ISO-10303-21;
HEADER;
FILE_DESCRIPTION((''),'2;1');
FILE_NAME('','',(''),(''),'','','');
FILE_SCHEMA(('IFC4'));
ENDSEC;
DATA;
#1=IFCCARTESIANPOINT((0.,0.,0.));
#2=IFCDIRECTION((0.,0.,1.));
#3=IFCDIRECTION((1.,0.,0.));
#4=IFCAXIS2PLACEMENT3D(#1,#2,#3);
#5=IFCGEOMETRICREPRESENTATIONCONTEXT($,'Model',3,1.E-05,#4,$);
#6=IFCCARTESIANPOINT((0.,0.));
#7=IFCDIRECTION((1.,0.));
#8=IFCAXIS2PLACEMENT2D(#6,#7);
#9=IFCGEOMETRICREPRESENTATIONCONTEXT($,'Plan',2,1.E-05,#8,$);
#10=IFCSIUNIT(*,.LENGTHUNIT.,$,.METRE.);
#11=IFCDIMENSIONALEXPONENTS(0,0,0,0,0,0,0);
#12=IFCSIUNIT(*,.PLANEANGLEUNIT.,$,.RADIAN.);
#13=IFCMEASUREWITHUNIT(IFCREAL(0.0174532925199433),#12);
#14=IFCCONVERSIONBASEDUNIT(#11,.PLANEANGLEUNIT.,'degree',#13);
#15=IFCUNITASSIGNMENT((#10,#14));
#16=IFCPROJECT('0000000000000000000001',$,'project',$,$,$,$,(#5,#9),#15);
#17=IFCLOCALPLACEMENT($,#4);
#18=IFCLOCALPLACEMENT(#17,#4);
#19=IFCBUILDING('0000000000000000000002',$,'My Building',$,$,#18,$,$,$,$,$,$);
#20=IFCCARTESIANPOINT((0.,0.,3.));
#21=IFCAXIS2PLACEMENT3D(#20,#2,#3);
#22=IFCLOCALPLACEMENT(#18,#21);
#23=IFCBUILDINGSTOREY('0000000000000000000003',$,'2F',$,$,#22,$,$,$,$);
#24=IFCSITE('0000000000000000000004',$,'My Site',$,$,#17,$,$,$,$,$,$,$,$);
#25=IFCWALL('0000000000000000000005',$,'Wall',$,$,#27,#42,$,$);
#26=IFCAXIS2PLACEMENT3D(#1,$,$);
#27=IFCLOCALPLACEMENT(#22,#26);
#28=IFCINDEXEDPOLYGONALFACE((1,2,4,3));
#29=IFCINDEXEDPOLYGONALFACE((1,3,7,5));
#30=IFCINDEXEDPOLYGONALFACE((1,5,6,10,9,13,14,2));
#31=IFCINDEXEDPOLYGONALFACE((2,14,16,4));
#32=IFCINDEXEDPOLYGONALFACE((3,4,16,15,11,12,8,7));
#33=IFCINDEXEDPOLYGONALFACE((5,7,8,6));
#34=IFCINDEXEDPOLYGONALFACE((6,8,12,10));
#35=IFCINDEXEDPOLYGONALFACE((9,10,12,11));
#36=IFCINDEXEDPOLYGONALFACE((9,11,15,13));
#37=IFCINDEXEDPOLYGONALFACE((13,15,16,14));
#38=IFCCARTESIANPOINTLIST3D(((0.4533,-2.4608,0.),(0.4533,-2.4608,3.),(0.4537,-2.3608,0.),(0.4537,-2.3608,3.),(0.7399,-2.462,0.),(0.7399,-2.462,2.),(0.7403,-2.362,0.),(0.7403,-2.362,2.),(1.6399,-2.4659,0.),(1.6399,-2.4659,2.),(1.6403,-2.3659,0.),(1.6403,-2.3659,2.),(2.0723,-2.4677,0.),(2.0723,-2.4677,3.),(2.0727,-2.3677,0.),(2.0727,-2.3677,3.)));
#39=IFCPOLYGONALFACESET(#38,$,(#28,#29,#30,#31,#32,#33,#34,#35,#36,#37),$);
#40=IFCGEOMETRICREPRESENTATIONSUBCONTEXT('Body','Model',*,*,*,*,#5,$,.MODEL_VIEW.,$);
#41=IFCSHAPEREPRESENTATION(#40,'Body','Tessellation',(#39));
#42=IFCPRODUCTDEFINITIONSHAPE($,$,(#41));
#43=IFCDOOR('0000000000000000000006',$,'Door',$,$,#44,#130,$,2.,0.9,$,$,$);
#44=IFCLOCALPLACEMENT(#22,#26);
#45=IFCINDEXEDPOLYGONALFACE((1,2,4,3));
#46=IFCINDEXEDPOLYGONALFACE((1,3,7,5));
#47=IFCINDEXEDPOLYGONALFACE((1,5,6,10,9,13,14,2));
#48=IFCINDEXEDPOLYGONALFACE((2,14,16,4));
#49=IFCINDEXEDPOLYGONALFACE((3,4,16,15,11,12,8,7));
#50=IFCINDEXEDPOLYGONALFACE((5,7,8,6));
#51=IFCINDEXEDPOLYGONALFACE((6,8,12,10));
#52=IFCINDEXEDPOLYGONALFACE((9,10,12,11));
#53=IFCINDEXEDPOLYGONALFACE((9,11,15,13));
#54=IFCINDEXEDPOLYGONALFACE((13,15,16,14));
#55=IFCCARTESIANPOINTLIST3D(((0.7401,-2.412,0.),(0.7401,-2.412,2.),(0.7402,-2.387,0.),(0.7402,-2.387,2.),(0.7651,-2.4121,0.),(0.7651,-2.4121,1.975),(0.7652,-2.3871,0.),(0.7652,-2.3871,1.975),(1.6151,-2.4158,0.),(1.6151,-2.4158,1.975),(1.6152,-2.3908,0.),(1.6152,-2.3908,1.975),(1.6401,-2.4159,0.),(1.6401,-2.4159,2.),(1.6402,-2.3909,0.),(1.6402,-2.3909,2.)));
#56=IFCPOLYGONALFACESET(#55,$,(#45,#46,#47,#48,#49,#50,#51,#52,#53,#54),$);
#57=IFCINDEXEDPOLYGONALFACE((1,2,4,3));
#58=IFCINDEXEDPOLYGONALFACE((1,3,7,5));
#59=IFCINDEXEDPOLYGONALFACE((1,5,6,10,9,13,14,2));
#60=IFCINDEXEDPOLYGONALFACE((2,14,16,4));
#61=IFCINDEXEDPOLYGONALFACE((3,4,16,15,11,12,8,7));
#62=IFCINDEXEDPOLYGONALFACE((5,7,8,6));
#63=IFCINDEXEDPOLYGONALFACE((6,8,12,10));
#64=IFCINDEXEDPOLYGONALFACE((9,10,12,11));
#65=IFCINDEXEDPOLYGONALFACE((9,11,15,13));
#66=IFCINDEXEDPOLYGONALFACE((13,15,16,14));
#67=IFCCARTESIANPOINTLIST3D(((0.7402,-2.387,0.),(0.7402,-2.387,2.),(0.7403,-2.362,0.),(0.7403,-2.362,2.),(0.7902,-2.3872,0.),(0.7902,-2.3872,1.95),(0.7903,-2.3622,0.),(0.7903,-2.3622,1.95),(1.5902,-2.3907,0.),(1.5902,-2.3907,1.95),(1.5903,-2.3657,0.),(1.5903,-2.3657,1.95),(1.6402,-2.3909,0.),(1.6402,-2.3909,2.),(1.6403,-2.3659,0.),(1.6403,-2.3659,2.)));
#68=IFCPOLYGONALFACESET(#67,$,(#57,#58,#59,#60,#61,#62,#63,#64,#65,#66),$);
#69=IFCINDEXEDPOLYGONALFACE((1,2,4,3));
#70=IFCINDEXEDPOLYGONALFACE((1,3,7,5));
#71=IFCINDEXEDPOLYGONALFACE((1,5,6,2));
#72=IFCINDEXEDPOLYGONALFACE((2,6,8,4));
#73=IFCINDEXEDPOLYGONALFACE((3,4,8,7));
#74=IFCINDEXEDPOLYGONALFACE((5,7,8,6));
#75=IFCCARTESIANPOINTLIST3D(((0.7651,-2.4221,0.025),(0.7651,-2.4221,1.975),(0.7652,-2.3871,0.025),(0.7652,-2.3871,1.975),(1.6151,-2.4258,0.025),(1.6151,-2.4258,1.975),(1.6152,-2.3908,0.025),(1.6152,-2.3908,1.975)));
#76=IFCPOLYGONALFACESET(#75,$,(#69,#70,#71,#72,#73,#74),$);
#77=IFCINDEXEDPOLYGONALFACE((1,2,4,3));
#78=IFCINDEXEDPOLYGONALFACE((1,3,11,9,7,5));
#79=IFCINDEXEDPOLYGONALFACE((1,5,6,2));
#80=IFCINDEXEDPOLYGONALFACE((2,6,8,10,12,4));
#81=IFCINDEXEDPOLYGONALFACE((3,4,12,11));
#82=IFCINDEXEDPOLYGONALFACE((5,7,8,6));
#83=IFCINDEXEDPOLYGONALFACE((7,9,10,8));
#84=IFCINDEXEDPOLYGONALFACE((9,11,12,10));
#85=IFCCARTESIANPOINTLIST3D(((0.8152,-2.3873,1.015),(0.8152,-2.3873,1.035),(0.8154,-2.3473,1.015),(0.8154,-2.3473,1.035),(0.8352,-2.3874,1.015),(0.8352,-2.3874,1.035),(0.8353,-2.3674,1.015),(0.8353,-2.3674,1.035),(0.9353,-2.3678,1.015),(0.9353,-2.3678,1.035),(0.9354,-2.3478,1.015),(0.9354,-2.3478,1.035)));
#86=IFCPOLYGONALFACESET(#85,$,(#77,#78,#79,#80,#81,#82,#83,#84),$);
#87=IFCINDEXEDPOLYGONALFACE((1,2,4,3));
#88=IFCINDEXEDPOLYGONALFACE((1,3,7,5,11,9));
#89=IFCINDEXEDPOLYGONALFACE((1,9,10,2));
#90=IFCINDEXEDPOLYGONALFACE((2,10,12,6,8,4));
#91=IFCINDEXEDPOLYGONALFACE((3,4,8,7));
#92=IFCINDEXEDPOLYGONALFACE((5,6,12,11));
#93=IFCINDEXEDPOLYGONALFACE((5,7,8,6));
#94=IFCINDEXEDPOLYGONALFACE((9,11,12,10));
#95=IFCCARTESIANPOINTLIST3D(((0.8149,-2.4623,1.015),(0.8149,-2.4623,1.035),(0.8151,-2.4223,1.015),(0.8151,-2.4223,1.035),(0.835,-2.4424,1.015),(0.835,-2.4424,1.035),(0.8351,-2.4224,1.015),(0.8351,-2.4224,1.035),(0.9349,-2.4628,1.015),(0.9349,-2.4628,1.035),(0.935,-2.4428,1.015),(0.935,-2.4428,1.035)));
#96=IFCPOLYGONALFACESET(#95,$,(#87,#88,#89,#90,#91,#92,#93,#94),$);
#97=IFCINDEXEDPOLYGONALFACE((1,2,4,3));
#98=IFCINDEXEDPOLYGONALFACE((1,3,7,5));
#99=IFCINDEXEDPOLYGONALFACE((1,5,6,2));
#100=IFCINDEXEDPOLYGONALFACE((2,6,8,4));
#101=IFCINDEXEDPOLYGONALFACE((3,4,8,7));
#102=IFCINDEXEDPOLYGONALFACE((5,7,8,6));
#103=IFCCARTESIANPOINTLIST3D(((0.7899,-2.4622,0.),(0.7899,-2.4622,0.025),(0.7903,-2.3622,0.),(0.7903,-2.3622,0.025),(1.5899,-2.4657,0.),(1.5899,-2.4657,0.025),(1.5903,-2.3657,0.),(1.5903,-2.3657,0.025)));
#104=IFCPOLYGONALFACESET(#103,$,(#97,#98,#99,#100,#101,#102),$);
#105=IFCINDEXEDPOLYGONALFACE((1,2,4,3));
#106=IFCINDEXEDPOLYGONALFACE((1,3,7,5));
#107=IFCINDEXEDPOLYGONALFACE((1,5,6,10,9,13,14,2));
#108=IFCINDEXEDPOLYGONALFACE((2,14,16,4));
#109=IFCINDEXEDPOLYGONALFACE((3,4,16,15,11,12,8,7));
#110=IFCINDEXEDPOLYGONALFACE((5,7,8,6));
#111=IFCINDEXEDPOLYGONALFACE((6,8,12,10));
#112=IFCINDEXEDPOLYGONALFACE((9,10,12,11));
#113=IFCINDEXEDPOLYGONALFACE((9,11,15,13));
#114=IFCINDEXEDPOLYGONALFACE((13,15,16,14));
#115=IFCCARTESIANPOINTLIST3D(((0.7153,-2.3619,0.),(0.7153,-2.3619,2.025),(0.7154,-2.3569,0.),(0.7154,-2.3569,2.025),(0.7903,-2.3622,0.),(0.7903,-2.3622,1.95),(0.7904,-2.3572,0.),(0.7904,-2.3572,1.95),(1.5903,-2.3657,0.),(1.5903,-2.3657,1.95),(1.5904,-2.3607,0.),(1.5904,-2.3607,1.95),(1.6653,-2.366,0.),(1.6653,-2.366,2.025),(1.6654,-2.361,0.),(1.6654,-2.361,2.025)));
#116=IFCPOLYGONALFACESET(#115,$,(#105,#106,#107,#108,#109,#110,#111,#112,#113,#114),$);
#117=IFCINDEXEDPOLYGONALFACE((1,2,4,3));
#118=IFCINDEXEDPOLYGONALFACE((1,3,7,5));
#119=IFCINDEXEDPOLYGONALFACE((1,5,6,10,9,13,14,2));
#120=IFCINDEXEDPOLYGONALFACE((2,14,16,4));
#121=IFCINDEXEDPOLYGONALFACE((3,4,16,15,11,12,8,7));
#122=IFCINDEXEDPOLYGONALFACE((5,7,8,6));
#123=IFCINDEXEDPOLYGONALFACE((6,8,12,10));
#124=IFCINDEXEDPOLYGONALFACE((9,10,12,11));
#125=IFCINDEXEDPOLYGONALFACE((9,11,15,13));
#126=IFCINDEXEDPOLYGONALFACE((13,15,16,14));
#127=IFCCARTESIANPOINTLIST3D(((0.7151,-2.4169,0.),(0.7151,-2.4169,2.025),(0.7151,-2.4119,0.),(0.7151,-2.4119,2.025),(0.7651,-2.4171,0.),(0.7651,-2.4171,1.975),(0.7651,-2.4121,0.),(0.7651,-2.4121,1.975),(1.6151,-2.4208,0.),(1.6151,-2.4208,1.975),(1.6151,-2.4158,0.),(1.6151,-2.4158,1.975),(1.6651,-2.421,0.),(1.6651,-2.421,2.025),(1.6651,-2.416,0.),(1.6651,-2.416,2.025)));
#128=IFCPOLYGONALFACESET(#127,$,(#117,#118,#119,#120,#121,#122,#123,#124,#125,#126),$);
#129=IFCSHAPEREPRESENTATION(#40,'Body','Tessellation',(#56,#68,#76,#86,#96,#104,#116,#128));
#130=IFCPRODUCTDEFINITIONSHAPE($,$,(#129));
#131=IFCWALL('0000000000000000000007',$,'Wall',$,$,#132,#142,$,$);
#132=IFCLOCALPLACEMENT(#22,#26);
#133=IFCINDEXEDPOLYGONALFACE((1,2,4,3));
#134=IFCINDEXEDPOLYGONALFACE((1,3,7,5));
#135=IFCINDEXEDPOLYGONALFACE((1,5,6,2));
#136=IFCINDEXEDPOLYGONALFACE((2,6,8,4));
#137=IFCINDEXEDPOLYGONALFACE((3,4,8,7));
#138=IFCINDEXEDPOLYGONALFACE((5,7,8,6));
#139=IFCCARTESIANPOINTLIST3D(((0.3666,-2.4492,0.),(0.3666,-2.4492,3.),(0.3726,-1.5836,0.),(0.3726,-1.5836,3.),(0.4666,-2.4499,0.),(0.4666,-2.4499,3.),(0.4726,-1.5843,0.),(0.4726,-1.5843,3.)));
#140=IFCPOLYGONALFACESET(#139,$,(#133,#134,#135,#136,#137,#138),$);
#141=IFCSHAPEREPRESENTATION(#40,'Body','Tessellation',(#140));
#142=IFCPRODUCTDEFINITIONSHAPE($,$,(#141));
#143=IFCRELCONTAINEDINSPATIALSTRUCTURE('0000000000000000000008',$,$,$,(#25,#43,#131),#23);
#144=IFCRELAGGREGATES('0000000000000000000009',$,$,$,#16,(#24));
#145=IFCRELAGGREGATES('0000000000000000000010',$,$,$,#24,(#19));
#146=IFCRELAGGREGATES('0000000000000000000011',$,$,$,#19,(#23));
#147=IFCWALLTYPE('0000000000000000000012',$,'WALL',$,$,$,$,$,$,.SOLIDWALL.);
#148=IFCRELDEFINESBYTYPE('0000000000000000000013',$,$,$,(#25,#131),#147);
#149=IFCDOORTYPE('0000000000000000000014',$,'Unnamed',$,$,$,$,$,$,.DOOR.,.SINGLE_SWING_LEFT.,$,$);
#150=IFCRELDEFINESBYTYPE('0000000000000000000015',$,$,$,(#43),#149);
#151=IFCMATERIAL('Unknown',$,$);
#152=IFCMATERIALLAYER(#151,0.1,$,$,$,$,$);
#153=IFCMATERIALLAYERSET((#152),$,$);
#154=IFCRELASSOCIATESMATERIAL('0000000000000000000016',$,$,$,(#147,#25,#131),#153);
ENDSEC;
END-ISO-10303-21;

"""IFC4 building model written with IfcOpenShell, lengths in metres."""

from ifc_helpers import new_model, entity, si_unit, converted_unit, frame, origin_with_axes, origin_2d_with_axis, place, context, subcontext, project, spatial, line, indexed_curve, outline, extrude, shape, source, transform, mapped, material, layer, layer_set, layer_usage, type_object, type_shapes, element, fill, save


model = new_model("IFC4")

# Units and contexts
model_context = context("Model", 3, precision=1e-05, world=origin_with_axes())
plan_context = context("Plan", 2, precision=1e-05, world=origin_2d_with_axis())
body_context_1 = subcontext(model_context, "Body", "Model", "MODEL_VIEW")
body_context_2 = subcontext(plan_context, "Body", "Plan", "PLAN_VIEW")
ifc_project = project(units=[si_unit("LENGTHUNIT", "METRE"), converted_unit("PLANEANGLEUNIT", "degree", entity("IfcReal", 0.0174532925199433), si_unit("PLANEANGLEUNIT", "RADIAN"), dimensions=[0, 0, 0, 0, 0, 0, 0])], contexts=[model_context, plan_context])

# Site, building, storey
site_placement = place(None, origin_with_axes())
site = spatial("IfcSite", under=ifc_project, at=site_placement, Name="My Site")
building_placement = place(site_placement, origin_with_axes())
building = spatial("IfcBuilding", under=site, at=building_placement, Name="My Building")
storey_placement = place(building_placement, frame((0.0, 0.0, 3.0), z_axis=(0.0, 0.0, 1.0), x_axis=(1.0, 0.0, 0.0)))
storey = spatial("IfcBuildingStorey", under=building, at=storey_placement, Name="2F")

# Shared definitions
ifc_material = material(Name="Unknown")

# Shared definitions
ifc_layer = layer(ifc_material, 0.1)
ifc_layer_set = layer_set([ifc_layer])
wall_type = type_object("IfcWallType", Name="WALL", PredefinedType="SOLIDWALL", material=ifc_layer_set)

# Wall, opening, door
ifc_layer_usage_1 = layer_usage(ifc_layer_set, "AXIS2", "POSITIVE", 0.0)
wall_1_placement = place(storey_placement, frame((2.0727, -2.3677, 0.0), z_axis=(0.0, 0.0, 1.0), x_axis=(-0.999991, 0.00431, 0.0)))
wall_1 = element("IfcWall", 1, at=wall_1_placement, inside=storey, type_object=wall_type, material=ifc_layer_usage_1, Name="Wall", context=body_context_1, shape_type="SweptSolid", body=[
    extrude(outline(indexed_curve([(0.0, 0.0), (0.0, 0.1), (1.619, 0.1), (1.619, 0.0)], segments=[line(1, 2, 3, 4, 1)])), origin_with_axes(), (0.0, 0.0, 1.0), 3.0),
])
shared_shape_1 = source(origin_with_axes(), body_context_1, "Body", "SweptSolid", [
    extrude(outline(indexed_curve([(0.0, 0.0), (0.9, 0.0), (0.9, 2.0), (0.0, 2.0)], segments=[line(1, 2, 3, 4, 1)])), frame((0.0, -0.6, 0.0), z_axis=(0.0, -1.0, 0.0), x_axis=(1.0, 0.0, 0.0)), (0.0, 0.0, -1.0), 1.2),
])
opening_1_placement = place(wall_1_placement, frame((0.4324, 0.0, 0.0), z_axis=(0.0, 0.0, 1.0), x_axis=(1.0, 0.0, 0.0)))
opening_1 = element("IfcOpeningElement", 2, at=opening_1_placement, cuts=wall_1, PredefinedType="OPENING", context=body_context_1, shape_type="MappedRepresentation", body=[
    mapped(shared_shape_1, transform((0.0, 0.0, 0.0), x_axis=(1.0, 0.0, 0.0), y_axis=(0.0, 1.0, 0.0), z_axis=(0.0, 0.0, 1.0), scale=1.0)),
])
door_type = type_object("IfcDoorType", Name="Unnamed", OperationType="SINGLE_SWING_LEFT", PredefinedType="DOOR")
shared_shape_2 = source(origin_with_axes(), body_context_1, "Body", "SweptSolid", [
    extrude(outline(indexed_curve([(0.0, 0.0), (0.0, 2.0), (0.9, 2.0), (0.9, 0.0), (0.875, 0.0), (0.875, 1.975), (0.025, 1.975), (0.025, 0.0)], segments=[line(1, 2, 3, 4, 5, 6, 7, 8, 1)])), frame((0.0, 0.025, 0.0), z_axis=(0.0, -1.0, 0.0), x_axis=(1.0, 0.0, 0.0)), (0.0, 0.0, -1.0), 0.025),
    extrude(outline(indexed_curve([(0.0, 0.0), (0.0, 2.0), (0.9, 2.0), (0.9, 0.0), (0.85, 0.0), (0.85, 1.95), (0.05, 1.95), (0.05, 0.0)], segments=[line(1, 2, 3, 4, 5, 6, 7, 8, 1)])), frame((0.0, 0.0, 0.0), z_axis=(0.0, -1.0, 0.0), x_axis=(1.0, 0.0, 0.0)), (0.0, 0.0, -1.0), 0.025),
    extrude(outline(indexed_curve([(0.0, 0.0), (0.85, 0.0), (0.85, 0.035), (0.0, 0.035)], segments=[line(1, 2, 3, 4, 1)])), frame((0.025, 0.025, 0.025), z_axis=(0.0, 0.0, 1.0), x_axis=(1.0, 0.0, 0.0)), (0.0, 0.0, 1.0), 1.95),
    extrude(outline(indexed_curve([(0.0, 0.0), (0.0, -0.04), (-0.12, -0.04), (-0.12, -0.02), (-0.02, -0.02), (-0.02, 0.0)], segments=[line(1, 2, 3, 4, 5, 6, 1)])), frame((0.825, 0.025, 1.015), z_axis=(0.0, 0.0, 1.0), x_axis=(1.0, 0.0, 0.0)), (0.0, 0.0, 1.0), 0.02),
    extrude(outline(indexed_curve([(0.0, 0.0), (0.0, 0.04), (-0.12, 0.04), (-0.12, 0.02), (-0.02, 0.02), (-0.02, 0.0)], segments=[line(1, 2, 3, 4, 5, 6, 1)])), frame((0.825, 0.06, 1.015), z_axis=(0.0, 0.0, 1.0), x_axis=(1.0, 0.0, 0.0)), (0.0, 0.0, 1.0), 0.02),
    extrude(outline(indexed_curve([(0.0, 0.0), (0.8, 0.0), (0.8, 0.1), (0.0, 0.1)], segments=[line(1, 2, 3, 4, 1)])), frame((0.05, 0.0, 0.0), z_axis=(0.0, 0.0, 1.0), x_axis=(1.0, 0.0, 0.0)), (0.0, 0.0, 1.0), 0.025),
    extrude(outline(indexed_curve([(0.0, 0.0), (0.0, 2.025), (0.95, 2.025), (0.95, 0.0), (0.875, 0.0), (0.875, 1.95), (0.075, 1.95), (0.075, 0.0)], segments=[line(1, 2, 3, 4, 5, 6, 7, 8, 1)])), frame((-0.025, -0.005, 0.0), z_axis=(0.0, -1.0, 0.0), x_axis=(1.0, 0.0, 0.0)), (0.0, 0.0, -1.0), 0.005),
    extrude(outline(indexed_curve([(0.0, 0.0), (0.0, 2.025), (0.95, 2.025), (0.95, 0.0), (0.9, 0.0), (0.9, 1.975), (0.05, 1.975), (0.05, 0.0)], segments=[line(1, 2, 3, 4, 5, 6, 7, 8, 1)])), frame((-0.025, 0.05, 0.0), z_axis=(0.0, -1.0, 0.0), x_axis=(1.0, 0.0, 0.0)), (0.0, 0.0, -1.0), 0.005),
])
shared_shape_3 = source(origin_with_axes(), body_context_2, "Body", "Curve2D", [
    entity("IfcIndexedPolyCurve", entity("IfcCartesianPointList2D", [[0.0, 0.0], [0.0, 0.05], [0.025, 0.05], [0.025, 0.025], [0.05, 0.025], [0.05, 0.0]]), [entity("IfcLineIndex", [1, 2, 3, 4, 5, 6, 1])]),
    entity("IfcIndexedPolyCurve", entity("IfcCartesianPointList2D", [[0.9, 0.0], [0.9, 0.05], [0.875, 0.05], [0.875, 0.025], [0.85, 0.025], [0.85, 0.0]]), [entity("IfcLineIndex", [1, 2, 3, 4, 5, 6, 1])]),
    entity("IfcTrimmedCurve", entity("IfcEllipse", entity("IfcAxis2Placement2D", entity("IfcCartesianPoint", [0.06, 0.05]), entity("IfcDirection", [1.0, 0.0])), 0.815, 0.85), [entity("IfcCartesianPoint", [0.875, 0.05])], [entity("IfcCartesianPoint", [0.06, 0.9])], True, "CARTESIAN"),
    entity("IfcIndexedPolyCurve", entity("IfcCartesianPointList2D", [[0.025, 0.05], [0.06, 0.05], [0.06, 0.9], [0.025, 0.9]]), [entity("IfcLineIndex", [1, 2, 3, 4, 1])]),
])
type_shapes(door_type, [shared_shape_2, shared_shape_3])
door_1_placement = place(opening_1_placement, frame((0.0, 0.0, 0.0), z_axis=(0.0, 0.0, 1.0), x_axis=(1.0, 0.0, 0.0)))
door_1 = element("IfcDoor", 3, at=door_1_placement, inside=storey, type_object=door_type, Name="Door", OverallHeight=2.0, OverallWidth=0.9, shapes=[
    shape(body_context_1, "Body", "MappedRepresentation", [mapped(shared_shape_2, transform((0.0, 0.0, 0.0), x_axis=(1.0, 0.0, 0.0), y_axis=(0.0, 1.0, 0.0), z_axis=(0.0, 0.0, 1.0), scale=1.0))]),
    shape(body_context_2, "Body", "MappedRepresentation", [mapped(shared_shape_3, transform((0.0, 0.0, 0.0), x_axis=(1.0, 0.0, 0.0), y_axis=(0.0, 1.0, 0.0), z_axis=(0.0, 0.0, 1.0), scale=1.0))]),
])
fill(opening_1, door_1)

# Wall
ifc_layer_usage_2 = layer_usage(ifc_layer_set, "AXIS2", "POSITIVE", 0.0)
wall_2_placement = place(storey_placement, frame((0.3726, -1.5836, 0.0), z_axis=(0.0, 0.0, 1.0), x_axis=(-0.006993, -0.999976, 0.0)))
element("IfcWall", 4, at=wall_2_placement, inside=storey, type_object=wall_type, material=ifc_layer_usage_2, Name="Wall", context=body_context_1, shape_type="SweptSolid", body=[
    extrude(outline(indexed_curve([(0.0, 0.0), (0.0, 0.1), (0.8656, 0.1), (0.8656, 0.0)], segments=[line(1, 2, 3, 4, 1)])), origin_with_axes(), (0.0, 0.0, 1.0), 3.0),
])

save(model, "model.ifc")
